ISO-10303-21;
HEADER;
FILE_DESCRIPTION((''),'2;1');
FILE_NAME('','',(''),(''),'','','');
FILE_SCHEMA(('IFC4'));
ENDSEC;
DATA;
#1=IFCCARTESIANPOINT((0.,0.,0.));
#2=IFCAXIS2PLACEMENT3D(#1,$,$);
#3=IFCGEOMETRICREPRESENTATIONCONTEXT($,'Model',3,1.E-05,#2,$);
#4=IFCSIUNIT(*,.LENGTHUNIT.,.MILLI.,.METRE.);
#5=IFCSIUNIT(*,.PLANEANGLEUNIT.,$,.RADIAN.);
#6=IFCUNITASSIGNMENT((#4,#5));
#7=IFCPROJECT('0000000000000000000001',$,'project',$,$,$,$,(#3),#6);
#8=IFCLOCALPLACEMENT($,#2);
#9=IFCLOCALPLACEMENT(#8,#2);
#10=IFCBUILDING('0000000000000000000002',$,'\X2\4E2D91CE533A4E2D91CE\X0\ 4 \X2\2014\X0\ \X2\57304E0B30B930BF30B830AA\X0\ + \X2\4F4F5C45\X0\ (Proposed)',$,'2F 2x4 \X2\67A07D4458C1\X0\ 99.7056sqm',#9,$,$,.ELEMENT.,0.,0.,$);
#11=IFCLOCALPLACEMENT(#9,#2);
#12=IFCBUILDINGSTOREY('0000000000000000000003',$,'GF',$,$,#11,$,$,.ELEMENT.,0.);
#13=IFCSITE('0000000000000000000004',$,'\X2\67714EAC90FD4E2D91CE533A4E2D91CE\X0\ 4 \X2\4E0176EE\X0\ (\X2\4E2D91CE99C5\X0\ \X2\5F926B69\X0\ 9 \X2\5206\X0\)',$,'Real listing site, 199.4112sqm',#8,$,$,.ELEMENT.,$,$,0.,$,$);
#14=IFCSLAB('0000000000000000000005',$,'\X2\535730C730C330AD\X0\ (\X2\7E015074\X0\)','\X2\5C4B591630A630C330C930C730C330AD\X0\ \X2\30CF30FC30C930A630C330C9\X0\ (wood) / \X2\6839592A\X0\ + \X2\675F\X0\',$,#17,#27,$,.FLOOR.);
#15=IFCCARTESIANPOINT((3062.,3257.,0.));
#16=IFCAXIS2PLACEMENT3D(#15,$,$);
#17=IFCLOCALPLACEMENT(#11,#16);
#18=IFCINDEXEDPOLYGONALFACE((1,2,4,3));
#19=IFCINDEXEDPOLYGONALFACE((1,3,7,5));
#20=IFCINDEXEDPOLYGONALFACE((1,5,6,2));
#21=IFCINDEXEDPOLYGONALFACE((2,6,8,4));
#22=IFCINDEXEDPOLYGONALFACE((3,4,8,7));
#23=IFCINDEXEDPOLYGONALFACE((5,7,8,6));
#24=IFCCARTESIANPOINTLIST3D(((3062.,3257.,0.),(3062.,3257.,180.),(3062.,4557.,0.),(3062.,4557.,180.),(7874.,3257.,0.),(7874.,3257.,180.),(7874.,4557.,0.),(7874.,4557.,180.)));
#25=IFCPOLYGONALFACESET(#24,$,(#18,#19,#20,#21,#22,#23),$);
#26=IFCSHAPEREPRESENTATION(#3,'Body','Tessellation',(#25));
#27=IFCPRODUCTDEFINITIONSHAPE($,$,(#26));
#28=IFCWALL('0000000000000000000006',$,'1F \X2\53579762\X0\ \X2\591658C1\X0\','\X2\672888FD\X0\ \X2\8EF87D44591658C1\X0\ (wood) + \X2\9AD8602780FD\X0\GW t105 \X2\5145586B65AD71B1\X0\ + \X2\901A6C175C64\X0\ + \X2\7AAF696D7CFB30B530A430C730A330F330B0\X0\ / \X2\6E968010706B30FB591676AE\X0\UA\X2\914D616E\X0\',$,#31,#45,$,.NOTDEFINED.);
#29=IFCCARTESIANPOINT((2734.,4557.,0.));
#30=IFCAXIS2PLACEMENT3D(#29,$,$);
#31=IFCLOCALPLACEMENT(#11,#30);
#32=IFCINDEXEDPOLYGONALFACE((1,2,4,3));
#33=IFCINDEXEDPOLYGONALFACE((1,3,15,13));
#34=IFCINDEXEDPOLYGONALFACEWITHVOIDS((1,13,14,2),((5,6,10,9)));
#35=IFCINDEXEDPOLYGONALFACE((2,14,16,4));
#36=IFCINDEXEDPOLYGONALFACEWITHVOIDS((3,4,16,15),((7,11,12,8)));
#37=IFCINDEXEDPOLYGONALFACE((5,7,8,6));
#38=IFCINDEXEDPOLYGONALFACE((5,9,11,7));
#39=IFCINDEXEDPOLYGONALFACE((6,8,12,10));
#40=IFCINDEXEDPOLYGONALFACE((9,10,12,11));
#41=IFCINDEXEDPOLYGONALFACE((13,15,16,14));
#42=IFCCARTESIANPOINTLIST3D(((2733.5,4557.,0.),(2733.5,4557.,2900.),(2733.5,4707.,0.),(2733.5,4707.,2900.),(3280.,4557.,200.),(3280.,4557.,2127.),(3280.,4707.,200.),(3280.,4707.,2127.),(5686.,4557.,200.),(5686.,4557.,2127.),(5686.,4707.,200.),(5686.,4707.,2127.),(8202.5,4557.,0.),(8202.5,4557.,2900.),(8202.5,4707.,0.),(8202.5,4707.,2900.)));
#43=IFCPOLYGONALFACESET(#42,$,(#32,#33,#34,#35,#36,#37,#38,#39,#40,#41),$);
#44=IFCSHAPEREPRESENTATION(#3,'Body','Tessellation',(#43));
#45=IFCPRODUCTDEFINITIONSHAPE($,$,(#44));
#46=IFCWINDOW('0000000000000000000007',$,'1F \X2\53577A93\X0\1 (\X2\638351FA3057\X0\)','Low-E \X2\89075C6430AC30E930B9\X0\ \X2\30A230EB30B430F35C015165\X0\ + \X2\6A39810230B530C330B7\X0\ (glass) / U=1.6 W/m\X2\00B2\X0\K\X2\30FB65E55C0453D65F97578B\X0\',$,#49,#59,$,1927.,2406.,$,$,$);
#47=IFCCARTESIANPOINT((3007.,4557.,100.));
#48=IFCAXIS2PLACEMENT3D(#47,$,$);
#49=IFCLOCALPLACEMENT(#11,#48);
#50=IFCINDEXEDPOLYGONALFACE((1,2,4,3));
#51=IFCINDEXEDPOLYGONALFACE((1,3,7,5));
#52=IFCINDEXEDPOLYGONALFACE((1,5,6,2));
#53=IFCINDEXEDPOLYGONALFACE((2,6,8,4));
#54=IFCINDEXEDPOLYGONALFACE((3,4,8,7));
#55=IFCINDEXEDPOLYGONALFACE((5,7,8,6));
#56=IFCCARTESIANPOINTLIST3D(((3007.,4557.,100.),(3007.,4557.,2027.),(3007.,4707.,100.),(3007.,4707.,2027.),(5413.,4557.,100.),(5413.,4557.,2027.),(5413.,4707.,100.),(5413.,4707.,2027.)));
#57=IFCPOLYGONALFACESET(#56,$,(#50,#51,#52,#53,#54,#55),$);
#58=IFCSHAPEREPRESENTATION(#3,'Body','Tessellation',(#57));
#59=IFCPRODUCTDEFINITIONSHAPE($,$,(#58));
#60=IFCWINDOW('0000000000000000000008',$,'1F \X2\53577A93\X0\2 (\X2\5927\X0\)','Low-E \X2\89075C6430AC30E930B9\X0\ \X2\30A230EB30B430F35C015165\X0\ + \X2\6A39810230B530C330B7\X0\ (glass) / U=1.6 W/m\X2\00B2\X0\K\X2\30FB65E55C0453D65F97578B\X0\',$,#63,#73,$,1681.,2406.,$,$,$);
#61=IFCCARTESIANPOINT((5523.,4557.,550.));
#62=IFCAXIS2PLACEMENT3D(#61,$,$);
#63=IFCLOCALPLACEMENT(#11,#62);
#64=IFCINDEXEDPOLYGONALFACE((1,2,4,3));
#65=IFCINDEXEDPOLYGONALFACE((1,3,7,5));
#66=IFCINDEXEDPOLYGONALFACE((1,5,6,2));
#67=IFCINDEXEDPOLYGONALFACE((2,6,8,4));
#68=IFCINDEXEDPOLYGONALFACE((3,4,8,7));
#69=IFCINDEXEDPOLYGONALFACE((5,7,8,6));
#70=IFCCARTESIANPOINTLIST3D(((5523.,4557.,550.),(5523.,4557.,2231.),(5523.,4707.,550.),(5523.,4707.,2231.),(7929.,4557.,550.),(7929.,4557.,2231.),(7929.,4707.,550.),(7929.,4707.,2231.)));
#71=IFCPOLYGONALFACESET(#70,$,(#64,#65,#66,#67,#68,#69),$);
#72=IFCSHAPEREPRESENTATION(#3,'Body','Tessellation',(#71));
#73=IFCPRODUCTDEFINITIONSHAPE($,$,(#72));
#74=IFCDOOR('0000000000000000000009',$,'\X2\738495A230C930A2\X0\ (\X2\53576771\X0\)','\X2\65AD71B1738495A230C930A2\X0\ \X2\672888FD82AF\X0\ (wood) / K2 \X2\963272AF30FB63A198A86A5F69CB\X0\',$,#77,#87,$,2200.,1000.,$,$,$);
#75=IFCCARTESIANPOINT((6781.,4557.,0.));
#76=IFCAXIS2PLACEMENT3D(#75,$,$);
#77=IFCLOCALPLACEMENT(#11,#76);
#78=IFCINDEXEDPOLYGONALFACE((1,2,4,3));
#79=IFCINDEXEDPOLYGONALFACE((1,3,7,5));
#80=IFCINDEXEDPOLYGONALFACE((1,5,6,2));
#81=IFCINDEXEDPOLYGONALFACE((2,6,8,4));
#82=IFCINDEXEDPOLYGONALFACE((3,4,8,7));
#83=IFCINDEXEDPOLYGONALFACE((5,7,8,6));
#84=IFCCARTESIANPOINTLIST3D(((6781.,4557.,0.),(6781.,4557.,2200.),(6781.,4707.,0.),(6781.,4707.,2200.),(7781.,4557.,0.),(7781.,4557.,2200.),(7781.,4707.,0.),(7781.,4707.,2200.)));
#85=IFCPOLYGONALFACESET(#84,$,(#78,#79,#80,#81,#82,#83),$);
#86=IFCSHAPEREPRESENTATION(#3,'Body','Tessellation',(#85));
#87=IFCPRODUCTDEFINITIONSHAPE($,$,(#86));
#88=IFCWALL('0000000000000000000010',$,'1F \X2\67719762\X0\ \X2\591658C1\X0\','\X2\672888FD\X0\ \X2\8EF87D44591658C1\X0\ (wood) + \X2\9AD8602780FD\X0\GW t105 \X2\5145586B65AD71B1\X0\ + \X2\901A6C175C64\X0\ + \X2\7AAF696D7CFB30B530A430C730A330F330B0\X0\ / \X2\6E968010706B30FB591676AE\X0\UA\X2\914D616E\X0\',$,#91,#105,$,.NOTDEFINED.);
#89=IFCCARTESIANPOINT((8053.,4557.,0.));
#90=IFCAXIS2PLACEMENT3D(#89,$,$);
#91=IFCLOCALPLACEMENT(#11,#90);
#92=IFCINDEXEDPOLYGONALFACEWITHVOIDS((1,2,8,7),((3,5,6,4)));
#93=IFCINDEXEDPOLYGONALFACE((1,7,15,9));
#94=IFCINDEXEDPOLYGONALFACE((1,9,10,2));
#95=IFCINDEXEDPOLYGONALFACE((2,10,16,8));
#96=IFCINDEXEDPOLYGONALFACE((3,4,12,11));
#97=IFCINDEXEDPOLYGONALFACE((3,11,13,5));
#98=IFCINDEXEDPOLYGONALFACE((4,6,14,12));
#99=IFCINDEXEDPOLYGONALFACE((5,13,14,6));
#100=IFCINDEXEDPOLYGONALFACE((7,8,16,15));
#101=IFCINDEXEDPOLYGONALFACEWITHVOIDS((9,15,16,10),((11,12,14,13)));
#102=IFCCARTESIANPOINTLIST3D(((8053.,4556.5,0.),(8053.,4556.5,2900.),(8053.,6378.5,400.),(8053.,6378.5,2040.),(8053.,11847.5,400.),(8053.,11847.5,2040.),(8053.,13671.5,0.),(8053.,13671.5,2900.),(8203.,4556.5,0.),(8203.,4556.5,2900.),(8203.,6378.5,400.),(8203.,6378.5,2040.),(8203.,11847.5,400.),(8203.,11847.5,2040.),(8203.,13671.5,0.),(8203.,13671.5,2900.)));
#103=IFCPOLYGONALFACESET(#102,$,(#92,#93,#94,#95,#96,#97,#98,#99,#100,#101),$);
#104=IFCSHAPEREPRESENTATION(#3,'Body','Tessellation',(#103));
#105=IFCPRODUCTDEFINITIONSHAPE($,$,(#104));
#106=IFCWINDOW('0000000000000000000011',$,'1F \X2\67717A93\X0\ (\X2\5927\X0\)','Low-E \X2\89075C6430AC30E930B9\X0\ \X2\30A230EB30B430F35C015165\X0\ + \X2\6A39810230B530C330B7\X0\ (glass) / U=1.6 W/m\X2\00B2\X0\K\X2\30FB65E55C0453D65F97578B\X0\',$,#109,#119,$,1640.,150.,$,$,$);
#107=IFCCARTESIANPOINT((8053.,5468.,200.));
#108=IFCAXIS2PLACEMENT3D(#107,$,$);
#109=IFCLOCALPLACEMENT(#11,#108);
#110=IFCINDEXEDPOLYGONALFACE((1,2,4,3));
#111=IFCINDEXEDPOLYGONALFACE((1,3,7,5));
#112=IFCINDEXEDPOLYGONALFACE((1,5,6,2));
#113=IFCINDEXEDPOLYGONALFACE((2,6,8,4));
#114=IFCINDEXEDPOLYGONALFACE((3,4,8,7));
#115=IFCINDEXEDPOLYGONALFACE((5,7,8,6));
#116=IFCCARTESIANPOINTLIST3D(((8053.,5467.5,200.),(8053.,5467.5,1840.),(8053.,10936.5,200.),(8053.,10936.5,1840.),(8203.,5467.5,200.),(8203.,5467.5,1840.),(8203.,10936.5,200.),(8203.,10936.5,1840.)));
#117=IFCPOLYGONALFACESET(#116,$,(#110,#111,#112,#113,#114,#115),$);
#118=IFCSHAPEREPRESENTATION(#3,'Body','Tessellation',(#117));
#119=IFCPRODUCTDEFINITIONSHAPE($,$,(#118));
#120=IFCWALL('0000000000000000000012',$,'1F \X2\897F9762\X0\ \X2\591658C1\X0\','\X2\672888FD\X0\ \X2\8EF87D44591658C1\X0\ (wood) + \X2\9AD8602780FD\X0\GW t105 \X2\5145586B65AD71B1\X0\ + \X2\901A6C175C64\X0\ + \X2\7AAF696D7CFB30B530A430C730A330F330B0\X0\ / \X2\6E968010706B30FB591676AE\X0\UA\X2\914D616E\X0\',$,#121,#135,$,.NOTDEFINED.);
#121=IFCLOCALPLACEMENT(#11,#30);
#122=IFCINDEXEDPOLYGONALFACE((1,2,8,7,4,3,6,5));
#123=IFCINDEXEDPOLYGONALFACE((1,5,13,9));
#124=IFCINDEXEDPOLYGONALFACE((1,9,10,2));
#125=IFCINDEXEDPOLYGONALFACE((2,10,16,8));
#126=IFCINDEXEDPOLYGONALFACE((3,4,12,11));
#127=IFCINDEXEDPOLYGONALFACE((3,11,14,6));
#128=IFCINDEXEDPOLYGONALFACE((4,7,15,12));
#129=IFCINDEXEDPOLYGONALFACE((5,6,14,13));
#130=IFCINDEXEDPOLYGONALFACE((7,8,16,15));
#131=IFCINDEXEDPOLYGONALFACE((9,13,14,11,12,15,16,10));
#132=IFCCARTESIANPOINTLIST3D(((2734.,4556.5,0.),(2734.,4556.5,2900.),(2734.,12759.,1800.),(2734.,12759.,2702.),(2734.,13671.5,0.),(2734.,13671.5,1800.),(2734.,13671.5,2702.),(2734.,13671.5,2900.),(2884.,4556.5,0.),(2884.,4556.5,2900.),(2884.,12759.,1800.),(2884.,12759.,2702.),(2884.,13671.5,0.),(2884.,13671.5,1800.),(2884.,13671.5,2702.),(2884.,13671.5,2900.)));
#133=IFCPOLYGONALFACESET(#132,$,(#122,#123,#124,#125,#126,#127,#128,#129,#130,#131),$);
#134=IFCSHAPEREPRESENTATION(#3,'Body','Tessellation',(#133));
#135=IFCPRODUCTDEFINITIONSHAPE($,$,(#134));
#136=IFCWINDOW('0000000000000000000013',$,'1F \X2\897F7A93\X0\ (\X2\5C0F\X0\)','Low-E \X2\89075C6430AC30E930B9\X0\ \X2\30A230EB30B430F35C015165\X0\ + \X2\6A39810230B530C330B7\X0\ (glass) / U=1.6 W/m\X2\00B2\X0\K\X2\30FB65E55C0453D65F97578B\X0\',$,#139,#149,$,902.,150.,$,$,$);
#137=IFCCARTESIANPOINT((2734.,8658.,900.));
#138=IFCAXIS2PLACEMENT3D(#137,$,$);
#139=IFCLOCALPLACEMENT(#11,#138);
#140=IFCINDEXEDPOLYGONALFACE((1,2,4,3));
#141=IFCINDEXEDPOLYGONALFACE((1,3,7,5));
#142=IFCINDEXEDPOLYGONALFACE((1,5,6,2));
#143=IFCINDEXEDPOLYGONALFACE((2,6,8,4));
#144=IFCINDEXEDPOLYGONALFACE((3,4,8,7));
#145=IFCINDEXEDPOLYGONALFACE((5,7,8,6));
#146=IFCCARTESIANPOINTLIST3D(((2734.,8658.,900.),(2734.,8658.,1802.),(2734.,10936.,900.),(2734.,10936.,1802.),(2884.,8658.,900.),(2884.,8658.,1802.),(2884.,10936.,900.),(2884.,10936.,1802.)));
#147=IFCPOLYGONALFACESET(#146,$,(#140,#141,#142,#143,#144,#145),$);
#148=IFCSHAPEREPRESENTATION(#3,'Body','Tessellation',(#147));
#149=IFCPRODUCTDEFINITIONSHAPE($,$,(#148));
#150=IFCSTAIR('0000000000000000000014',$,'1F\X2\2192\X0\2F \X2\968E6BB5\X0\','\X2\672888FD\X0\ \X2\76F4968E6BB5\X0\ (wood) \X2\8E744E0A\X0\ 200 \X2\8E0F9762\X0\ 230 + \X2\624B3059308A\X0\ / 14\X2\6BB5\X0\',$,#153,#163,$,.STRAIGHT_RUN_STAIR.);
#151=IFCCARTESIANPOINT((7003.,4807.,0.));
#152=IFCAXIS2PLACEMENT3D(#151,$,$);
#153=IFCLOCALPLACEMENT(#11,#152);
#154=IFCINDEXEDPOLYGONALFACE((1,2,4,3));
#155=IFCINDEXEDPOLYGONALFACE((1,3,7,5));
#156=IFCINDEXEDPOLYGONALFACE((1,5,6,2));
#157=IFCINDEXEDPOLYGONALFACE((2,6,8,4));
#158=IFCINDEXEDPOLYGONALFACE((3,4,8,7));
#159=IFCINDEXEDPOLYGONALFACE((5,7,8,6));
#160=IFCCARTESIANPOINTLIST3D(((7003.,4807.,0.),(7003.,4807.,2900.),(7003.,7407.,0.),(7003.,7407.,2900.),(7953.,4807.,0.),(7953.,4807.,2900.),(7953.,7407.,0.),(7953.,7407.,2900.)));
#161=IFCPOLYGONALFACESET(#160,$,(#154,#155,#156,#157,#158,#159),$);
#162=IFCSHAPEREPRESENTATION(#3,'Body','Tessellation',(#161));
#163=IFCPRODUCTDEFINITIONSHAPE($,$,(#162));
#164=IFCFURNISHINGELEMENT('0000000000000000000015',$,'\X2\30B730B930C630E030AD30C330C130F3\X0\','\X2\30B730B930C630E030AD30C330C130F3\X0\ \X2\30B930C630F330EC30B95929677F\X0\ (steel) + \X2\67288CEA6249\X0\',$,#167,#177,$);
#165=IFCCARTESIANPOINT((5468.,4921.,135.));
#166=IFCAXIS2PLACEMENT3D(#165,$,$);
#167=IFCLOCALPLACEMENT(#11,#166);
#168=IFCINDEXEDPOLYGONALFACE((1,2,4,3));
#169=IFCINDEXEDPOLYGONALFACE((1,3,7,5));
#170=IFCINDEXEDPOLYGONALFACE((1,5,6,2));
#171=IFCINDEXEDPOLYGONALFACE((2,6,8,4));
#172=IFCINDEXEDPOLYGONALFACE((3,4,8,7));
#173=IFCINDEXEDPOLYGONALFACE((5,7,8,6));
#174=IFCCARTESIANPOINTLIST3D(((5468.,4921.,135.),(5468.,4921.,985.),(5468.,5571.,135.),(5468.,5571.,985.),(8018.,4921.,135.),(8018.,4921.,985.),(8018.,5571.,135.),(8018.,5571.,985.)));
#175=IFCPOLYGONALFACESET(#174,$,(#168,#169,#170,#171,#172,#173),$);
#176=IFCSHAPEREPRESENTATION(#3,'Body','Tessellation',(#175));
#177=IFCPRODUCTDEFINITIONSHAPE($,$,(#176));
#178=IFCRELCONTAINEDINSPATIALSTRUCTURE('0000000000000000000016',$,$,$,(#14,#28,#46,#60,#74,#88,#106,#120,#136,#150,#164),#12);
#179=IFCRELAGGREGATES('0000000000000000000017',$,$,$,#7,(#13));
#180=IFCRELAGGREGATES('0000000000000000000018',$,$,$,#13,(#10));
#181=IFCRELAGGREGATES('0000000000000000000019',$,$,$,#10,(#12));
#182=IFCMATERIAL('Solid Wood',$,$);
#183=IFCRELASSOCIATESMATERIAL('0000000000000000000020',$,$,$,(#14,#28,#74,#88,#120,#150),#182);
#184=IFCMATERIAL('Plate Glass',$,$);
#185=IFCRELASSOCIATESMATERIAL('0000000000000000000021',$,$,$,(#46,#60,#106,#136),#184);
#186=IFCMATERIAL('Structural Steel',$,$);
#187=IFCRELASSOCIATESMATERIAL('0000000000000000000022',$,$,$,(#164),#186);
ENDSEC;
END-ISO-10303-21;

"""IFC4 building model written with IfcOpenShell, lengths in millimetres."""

from ifc_helpers import new_model, si_unit, frame, frame_2d, origin, place, context, project, spatial, rectangle, extrude, material, element, fill, save


model = new_model("IFC4")

# Units and contexts
model_context = context("Model", 3, precision=1e-05, world=origin())
ifc_project = project(units=[si_unit("LENGTHUNIT", "METRE", prefix="MILLI"), si_unit("PLANEANGLEUNIT", "RADIAN")], contexts=[model_context])

# Site, building, storey
site_placement = place(None, origin())
site = spatial("IfcSite", under=ifc_project, at=site_placement, Name="東京都中野区中野 4 丁目 (中野駅 徒歩 9 分)", ObjectType="Real listing site, 199.4112sqm", CompositionType="ELEMENT", RefElevation=0.0)
building_placement = place(site_placement, origin())
building = spatial("IfcBuilding", under=site, at=building_placement, Name="中野区中野 4 — 地下スタジオ + 住居 (Proposed)", ObjectType="2F 2x4 枠組壁 99.7056sqm", CompositionType="ELEMENT", ElevationOfRefHeight=0.0, ElevationOfTerrain=0.0)
storey_placement = place(building_placement, origin())
storey = spatial("IfcBuildingStorey", under=building, at=storey_placement, Name="GF", CompositionType="ELEMENT", Elevation=0.0)

# Slab
ifc_material_1 = material(Name="Solid Wood")
slab_1_placement = place(storey_placement, frame((3062.0, 3257.0, 0.0)))
element("IfcSlab", 1, at=slab_1_placement, inside=storey, material=ifc_material_1, Name="南デッキ (縁側)", Description="屋外ウッドデッキ ハードウッド (wood) / 根太 + 束", PredefinedType="FLOOR", context=model_context, shape_type="SweptSolid", body=[
    extrude(rectangle(XDim=4812.0, YDim=1300.0, at=frame_2d((2406.0, 650.0))), frame((3062.0, 3257.0, 0.0)), (0.0, 0.0, 1.0), 180.0),
])

# Wall, openings, windows, door
wall_1_placement = place(storey_placement, frame((2734.0, 4557.0, 0.0)))
wall_1 = element("IfcWall", 2, at=wall_1_placement, inside=storey, material=ifc_material_1, Name="1F 南面 外壁", Description="木製 軸組外壁 (wood) + 高性能GW t105 充填断熱 + 通気層 + 窯業系サイディング / 準耐火・外皮UA配慮", PredefinedType="NOTDEFINED", context=model_context, shape_type="SweptSolid", body=[
    extrude(rectangle(XDim=5469.0, YDim=150.0, at=frame_2d((2734.0, 75.0))), frame((2734.0, 4557.0, 0.0)), (0.0, 0.0, 1.0), 2900.0),
])
opening_1_placement = place(storey_placement, frame((3007.0, 4557.0, 100.0)))
opening_1 = element("IfcOpeningElement", 3, at=opening_1_placement, cuts=wall_1, PredefinedType="NOTDEFINED", context=model_context, shape_type="SweptSolid", body=[
    extrude(rectangle(XDim=2406.0, YDim=150.0, at=frame_2d((1203.0, 75.0))), frame((3007.0, 4557.0, 100.0)), (0.0, 0.0, 1.0), 1927.0),
])
opening_2_placement = place(storey_placement, frame((5523.0, 4557.0, 550.0)))
opening_2 = element("IfcOpeningElement", 4, at=opening_2_placement, cuts=wall_1, PredefinedType="NOTDEFINED", context=model_context, shape_type="SweptSolid", body=[
    extrude(rectangle(XDim=2406.0, YDim=150.0, at=frame_2d((1203.0, 75.0))), frame((5523.0, 4557.0, 550.0)), (0.0, 0.0, 1.0), 1681.0),
])
opening_3_placement = place(storey_placement, frame((6781.0, 4557.0, 0.0)))
opening_3 = element("IfcOpeningElement", 5, at=opening_3_placement, cuts=wall_1, PredefinedType="NOTDEFINED", context=model_context, shape_type="SweptSolid", body=[
    extrude(rectangle(XDim=1000.0, YDim=150.0, at=frame_2d((500.0, 75.0))), frame((6781.0, 4557.0, 0.0)), (0.0, 0.0, 1.0), 2200.0),
])
ifc_material_2 = material(Name="Plate Glass")
window_1_placement = place(storey_placement, frame((3007.0, 4557.0, 100.0)))
window_1 = element("IfcWindow", 6, at=window_1_placement, inside=storey, material=ifc_material_2, Name="1F 南窓1 (掃出し)", Description="Low-E 複層ガラス アルゴン封入 + 樹脂サッシ (glass) / U=1.6 W/m²K・日射取得型", OverallHeight=1927.0, OverallWidth=2406.0, context=model_context, shape_type="SweptSolid", body=[
    extrude(rectangle(XDim=2406.0, YDim=150.0, at=frame_2d((1203.0, 75.0))), frame((3007.0, 4557.0, 100.0)), (0.0, 0.0, 1.0), 1927.0),
])
fill(opening_1, window_1)
window_2_placement = place(storey_placement, frame((5523.0, 4557.0, 550.0)))
window_2 = element("IfcWindow", 7, at=window_2_placement, inside=storey, material=ifc_material_2, Name="1F 南窓2 (大)", Description="Low-E 複層ガラス アルゴン封入 + 樹脂サッシ (glass) / U=1.6 W/m²K・日射取得型", OverallHeight=1681.0, OverallWidth=2406.0, context=model_context, shape_type="SweptSolid", body=[
    extrude(rectangle(XDim=2406.0, YDim=150.0, at=frame_2d((1203.0, 75.0))), frame((5523.0, 4557.0, 550.0)), (0.0, 0.0, 1.0), 1681.0),
])
fill(opening_2, window_2)
door_placement = place(storey_placement, frame((6781.0, 4557.0, 0.0)))
door = element("IfcDoor", 8, at=door_placement, inside=storey, material=ifc_material_1, Name="玄関ドア (南東)", Description="断熱玄関ドア 木製芯 (wood) / K2 防犯・採風機構", OverallHeight=2200.0, OverallWidth=1000.0, context=model_context, shape_type="SweptSolid", body=[
    extrude(rectangle(XDim=1000.0, YDim=150.0, at=frame_2d((500.0, 75.0))), frame((6781.0, 4557.0, 0.0)), (0.0, 0.0, 1.0), 2200.0),
])
fill(opening_3, door)

# Walls, openings, windows
wall_2_placement = place(storey_placement, frame((8053.0, 4557.0, 0.0)))
wall_2 = element("IfcWall", 9, at=wall_2_placement, inside=storey, material=ifc_material_1, Name="1F 東面 外壁", Description="木製 軸組外壁 (wood) + 高性能GW t105 充填断熱 + 通気層 + 窯業系サイディング / 準耐火・外皮UA配慮", PredefinedType="NOTDEFINED", context=model_context, shape_type="SweptSolid", body=[
    extrude(rectangle(XDim=150.0, YDim=9115.0, at=frame_2d((75.0, 4557.0))), frame((8053.0, 4557.0, 0.0)), (0.0, 0.0, 1.0), 2900.0),
])
opening_4_placement = place(storey_placement, frame((8053.0, 5468.0, 200.0)))
opening_4 = element("IfcOpeningElement", 10, at=opening_4_placement, cuts=wall_2, PredefinedType="NOTDEFINED", context=model_context, shape_type="SweptSolid", body=[
    extrude(rectangle(XDim=150.0, YDim=5469.0, at=frame_2d((75.0, 2734.0))), frame((8053.0, 5468.0, 200.0)), (0.0, 0.0, 1.0), 1640.0),
])
window_3_placement = place(storey_placement, frame((8053.0, 5468.0, 200.0)))
window_3 = element("IfcWindow", 11, at=window_3_placement, inside=storey, material=ifc_material_2, Name="1F 東窓 (大)", Description="Low-E 複層ガラス アルゴン封入 + 樹脂サッシ (glass) / U=1.6 W/m²K・日射取得型", OverallHeight=1640.0, OverallWidth=150.0, context=model_context, shape_type="SweptSolid", body=[
    extrude(rectangle(XDim=150.0, YDim=5469.0, at=frame_2d((75.0, 2734.0))), frame((8053.0, 5468.0, 200.0)), (0.0, 0.0, 1.0), 1640.0),
])
fill(opening_4, window_3)
wall_3_placement = place(storey_placement, frame((2734.0, 4557.0, 0.0)))
wall_3 = element("IfcWall", 12, at=wall_3_placement, inside=storey, material=ifc_material_1, Name="1F 西面 外壁", Description="木製 軸組外壁 (wood) + 高性能GW t105 充填断熱 + 通気層 + 窯業系サイディング / 準耐火・外皮UA配慮", PredefinedType="NOTDEFINED", context=model_context, shape_type="SweptSolid", body=[
    extrude(rectangle(XDim=150.0, YDim=9115.0, at=frame_2d((75.0, 4557.0))), frame((2734.0, 4557.0, 0.0)), (0.0, 0.0, 1.0), 2900.0),
])
opening_5_placement = place(storey_placement, frame((2734.0, 8658.0, 900.0)))
opening_5 = element("IfcOpeningElement", 13, at=opening_5_placement, cuts=wall_3, PredefinedType="NOTDEFINED", context=model_context, shape_type="SweptSolid", body=[
    extrude(rectangle(XDim=150.0, YDim=2278.0, at=frame_2d((75.0, 1139.0))), frame((2734.0, 8658.0, 900.0)), (0.0, 0.0, 1.0), 902.0),
])
window_4_placement = place(storey_placement, frame((2734.0, 8658.0, 900.0)))
window_4 = element("IfcWindow", 14, at=window_4_placement, inside=storey, material=ifc_material_2, Name="1F 西窓 (小)", Description="Low-E 複層ガラス アルゴン封入 + 樹脂サッシ (glass) / U=1.6 W/m²K・日射取得型", OverallHeight=902.0, OverallWidth=150.0, context=model_context, shape_type="SweptSolid", body=[
    extrude(rectangle(XDim=150.0, YDim=2278.0, at=frame_2d((75.0, 1139.0))), frame((2734.0, 8658.0, 900.0)), (0.0, 0.0, 1.0), 902.0),
])
fill(opening_5, window_4)

# Stair
stair_placement = place(storey_placement, frame((7003.0, 4807.0, 0.0)))
element("IfcStair", 15, at=stair_placement, inside=storey, material=ifc_material_1, Name="1F→2F 階段", Description="木製 直階段 (wood) 蹴上 200 踏面 230 + 手すり / 14段", PredefinedType="STRAIGHT_RUN_STAIR", context=model_context, shape_type="SweptSolid", body=[
    extrude(rectangle(XDim=950.0, YDim=2600.0, at=frame_2d((475.0, 1300.0))), frame((7003.0, 4807.0, 0.0)), (0.0, 0.0, 1.0), 2900.0),
])

# Furnishing element
ifc_material_3 = material(Name="Structural Steel")
furnishing_placement = place(storey_placement, frame((5468.0, 4921.0, 135.0)))
element("IfcFurnishingElement", 16, at=furnishing_placement, inside=storey, material=ifc_material_3, Name="システムキッチン", Description="システムキッチン ステンレス天板 (steel) + 木質扉", context=model_context, shape_type="SweptSolid", body=[
    extrude(rectangle(XDim=2550.0, YDim=650.0, at=frame_2d((1275.0, 325.0))), frame((5468.0, 4921.0, 135.0)), (0.0, 0.0, 1.0), 850.0),
])

save(model, "model.ifc")
